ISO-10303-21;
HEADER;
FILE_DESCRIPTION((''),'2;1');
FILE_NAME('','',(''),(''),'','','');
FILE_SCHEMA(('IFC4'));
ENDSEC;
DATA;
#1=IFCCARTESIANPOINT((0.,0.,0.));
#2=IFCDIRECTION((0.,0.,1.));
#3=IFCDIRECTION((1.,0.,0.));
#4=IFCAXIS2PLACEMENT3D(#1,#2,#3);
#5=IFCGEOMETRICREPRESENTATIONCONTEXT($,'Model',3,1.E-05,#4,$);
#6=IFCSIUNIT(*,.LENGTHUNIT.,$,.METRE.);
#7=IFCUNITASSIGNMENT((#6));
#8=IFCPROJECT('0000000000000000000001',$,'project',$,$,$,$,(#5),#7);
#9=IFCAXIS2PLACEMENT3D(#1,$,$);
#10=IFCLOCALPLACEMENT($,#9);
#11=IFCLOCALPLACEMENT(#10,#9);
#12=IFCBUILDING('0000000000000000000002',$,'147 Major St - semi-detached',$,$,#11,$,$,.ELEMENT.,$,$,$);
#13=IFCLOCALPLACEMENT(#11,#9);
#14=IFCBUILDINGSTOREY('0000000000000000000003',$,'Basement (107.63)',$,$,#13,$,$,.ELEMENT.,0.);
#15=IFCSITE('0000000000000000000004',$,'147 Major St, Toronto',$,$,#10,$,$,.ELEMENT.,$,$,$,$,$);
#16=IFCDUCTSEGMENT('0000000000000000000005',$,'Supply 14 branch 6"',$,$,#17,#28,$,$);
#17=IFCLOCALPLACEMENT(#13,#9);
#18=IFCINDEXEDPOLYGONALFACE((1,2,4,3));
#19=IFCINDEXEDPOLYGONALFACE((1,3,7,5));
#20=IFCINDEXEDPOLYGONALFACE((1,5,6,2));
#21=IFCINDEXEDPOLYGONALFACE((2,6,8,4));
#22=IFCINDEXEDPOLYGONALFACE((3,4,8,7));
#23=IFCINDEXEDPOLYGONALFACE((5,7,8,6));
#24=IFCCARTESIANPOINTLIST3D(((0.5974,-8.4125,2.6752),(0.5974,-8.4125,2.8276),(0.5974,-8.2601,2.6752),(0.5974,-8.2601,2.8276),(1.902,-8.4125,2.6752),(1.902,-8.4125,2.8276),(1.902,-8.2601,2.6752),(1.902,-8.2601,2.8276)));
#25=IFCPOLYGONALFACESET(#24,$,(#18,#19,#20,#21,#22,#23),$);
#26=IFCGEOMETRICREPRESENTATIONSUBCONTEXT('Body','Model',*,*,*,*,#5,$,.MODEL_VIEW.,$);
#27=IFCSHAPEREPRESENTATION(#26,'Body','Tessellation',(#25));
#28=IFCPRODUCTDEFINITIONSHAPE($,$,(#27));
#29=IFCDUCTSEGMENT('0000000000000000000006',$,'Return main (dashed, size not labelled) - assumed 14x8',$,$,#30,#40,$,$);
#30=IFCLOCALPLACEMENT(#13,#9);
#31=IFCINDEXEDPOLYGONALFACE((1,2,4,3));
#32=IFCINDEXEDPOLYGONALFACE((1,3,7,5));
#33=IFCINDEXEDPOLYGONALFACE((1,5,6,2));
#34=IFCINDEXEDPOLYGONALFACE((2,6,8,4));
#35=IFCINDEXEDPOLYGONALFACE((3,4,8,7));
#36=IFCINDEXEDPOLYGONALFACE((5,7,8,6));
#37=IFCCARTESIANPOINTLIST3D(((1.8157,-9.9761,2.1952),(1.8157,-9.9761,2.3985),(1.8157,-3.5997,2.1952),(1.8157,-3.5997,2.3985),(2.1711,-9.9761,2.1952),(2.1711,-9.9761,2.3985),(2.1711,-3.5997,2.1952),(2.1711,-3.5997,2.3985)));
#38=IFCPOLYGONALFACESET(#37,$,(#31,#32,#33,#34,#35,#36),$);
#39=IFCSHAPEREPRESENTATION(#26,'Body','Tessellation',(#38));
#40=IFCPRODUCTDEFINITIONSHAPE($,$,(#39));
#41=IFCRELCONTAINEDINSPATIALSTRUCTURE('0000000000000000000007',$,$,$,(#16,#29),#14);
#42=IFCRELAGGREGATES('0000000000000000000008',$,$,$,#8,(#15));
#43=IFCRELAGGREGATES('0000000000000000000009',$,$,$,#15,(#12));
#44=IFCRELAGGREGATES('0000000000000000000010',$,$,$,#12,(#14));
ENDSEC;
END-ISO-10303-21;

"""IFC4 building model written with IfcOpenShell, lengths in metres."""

from ifc_helpers import new_model, si_unit, frame, origin, origin_with_axes, place, context, subcontext, project, spatial, rectangle, extrude, element, save


model = new_model("IFC4")

# Units and contexts
model_context = context("Model", 3, precision=1e-05, world=origin_with_axes())
body_context = subcontext(model_context, "Body", "Model", "MODEL_VIEW")
ifc_project = project(units=[si_unit("LENGTHUNIT", "METRE")], contexts=[model_context])

# Site, building, storey
site_placement = place(None, origin())
site = spatial("IfcSite", under=ifc_project, at=site_placement, Name="147 Major St, Toronto", CompositionType="ELEMENT")
building_placement = place(site_placement, origin())
building = spatial("IfcBuilding", under=site, at=building_placement, Name="147 Major St - semi-detached", CompositionType="ELEMENT")
storey_placement = place(building_placement, origin())
storey = spatial("IfcBuildingStorey", under=building, at=storey_placement, Name="Basement (107.63)", CompositionType="ELEMENT", Elevation=0.0)

# Duct segments
duct_segment_1_placement = place(storey_placement, frame((1.2497, -8.3363, 2.6752)))
element("IfcDuctSegment", 1, at=duct_segment_1_placement, inside=storey, Name="Supply 14 branch 6\"", context=body_context, shape_type="SweptSolid", body=[
    extrude(rectangle(XDim=1.3045, YDim=0.1524), origin_with_axes(), (0.0, 0.0, 1.0), 0.1524),
])
duct_segment_2_placement = place(storey_placement, frame((1.9934, -6.7879, 2.1952)))
element("IfcDuctSegment", 2, at=duct_segment_2_placement, inside=storey, Name="Return main (dashed, size not labelled) - assumed 14x8", context=body_context, shape_type="SweptSolid", body=[
    extrude(rectangle(XDim=0.3554, YDim=6.3764), origin_with_axes(), (0.0, 0.0, 1.0), 0.2033),
])

save(model, "model.ifc")
